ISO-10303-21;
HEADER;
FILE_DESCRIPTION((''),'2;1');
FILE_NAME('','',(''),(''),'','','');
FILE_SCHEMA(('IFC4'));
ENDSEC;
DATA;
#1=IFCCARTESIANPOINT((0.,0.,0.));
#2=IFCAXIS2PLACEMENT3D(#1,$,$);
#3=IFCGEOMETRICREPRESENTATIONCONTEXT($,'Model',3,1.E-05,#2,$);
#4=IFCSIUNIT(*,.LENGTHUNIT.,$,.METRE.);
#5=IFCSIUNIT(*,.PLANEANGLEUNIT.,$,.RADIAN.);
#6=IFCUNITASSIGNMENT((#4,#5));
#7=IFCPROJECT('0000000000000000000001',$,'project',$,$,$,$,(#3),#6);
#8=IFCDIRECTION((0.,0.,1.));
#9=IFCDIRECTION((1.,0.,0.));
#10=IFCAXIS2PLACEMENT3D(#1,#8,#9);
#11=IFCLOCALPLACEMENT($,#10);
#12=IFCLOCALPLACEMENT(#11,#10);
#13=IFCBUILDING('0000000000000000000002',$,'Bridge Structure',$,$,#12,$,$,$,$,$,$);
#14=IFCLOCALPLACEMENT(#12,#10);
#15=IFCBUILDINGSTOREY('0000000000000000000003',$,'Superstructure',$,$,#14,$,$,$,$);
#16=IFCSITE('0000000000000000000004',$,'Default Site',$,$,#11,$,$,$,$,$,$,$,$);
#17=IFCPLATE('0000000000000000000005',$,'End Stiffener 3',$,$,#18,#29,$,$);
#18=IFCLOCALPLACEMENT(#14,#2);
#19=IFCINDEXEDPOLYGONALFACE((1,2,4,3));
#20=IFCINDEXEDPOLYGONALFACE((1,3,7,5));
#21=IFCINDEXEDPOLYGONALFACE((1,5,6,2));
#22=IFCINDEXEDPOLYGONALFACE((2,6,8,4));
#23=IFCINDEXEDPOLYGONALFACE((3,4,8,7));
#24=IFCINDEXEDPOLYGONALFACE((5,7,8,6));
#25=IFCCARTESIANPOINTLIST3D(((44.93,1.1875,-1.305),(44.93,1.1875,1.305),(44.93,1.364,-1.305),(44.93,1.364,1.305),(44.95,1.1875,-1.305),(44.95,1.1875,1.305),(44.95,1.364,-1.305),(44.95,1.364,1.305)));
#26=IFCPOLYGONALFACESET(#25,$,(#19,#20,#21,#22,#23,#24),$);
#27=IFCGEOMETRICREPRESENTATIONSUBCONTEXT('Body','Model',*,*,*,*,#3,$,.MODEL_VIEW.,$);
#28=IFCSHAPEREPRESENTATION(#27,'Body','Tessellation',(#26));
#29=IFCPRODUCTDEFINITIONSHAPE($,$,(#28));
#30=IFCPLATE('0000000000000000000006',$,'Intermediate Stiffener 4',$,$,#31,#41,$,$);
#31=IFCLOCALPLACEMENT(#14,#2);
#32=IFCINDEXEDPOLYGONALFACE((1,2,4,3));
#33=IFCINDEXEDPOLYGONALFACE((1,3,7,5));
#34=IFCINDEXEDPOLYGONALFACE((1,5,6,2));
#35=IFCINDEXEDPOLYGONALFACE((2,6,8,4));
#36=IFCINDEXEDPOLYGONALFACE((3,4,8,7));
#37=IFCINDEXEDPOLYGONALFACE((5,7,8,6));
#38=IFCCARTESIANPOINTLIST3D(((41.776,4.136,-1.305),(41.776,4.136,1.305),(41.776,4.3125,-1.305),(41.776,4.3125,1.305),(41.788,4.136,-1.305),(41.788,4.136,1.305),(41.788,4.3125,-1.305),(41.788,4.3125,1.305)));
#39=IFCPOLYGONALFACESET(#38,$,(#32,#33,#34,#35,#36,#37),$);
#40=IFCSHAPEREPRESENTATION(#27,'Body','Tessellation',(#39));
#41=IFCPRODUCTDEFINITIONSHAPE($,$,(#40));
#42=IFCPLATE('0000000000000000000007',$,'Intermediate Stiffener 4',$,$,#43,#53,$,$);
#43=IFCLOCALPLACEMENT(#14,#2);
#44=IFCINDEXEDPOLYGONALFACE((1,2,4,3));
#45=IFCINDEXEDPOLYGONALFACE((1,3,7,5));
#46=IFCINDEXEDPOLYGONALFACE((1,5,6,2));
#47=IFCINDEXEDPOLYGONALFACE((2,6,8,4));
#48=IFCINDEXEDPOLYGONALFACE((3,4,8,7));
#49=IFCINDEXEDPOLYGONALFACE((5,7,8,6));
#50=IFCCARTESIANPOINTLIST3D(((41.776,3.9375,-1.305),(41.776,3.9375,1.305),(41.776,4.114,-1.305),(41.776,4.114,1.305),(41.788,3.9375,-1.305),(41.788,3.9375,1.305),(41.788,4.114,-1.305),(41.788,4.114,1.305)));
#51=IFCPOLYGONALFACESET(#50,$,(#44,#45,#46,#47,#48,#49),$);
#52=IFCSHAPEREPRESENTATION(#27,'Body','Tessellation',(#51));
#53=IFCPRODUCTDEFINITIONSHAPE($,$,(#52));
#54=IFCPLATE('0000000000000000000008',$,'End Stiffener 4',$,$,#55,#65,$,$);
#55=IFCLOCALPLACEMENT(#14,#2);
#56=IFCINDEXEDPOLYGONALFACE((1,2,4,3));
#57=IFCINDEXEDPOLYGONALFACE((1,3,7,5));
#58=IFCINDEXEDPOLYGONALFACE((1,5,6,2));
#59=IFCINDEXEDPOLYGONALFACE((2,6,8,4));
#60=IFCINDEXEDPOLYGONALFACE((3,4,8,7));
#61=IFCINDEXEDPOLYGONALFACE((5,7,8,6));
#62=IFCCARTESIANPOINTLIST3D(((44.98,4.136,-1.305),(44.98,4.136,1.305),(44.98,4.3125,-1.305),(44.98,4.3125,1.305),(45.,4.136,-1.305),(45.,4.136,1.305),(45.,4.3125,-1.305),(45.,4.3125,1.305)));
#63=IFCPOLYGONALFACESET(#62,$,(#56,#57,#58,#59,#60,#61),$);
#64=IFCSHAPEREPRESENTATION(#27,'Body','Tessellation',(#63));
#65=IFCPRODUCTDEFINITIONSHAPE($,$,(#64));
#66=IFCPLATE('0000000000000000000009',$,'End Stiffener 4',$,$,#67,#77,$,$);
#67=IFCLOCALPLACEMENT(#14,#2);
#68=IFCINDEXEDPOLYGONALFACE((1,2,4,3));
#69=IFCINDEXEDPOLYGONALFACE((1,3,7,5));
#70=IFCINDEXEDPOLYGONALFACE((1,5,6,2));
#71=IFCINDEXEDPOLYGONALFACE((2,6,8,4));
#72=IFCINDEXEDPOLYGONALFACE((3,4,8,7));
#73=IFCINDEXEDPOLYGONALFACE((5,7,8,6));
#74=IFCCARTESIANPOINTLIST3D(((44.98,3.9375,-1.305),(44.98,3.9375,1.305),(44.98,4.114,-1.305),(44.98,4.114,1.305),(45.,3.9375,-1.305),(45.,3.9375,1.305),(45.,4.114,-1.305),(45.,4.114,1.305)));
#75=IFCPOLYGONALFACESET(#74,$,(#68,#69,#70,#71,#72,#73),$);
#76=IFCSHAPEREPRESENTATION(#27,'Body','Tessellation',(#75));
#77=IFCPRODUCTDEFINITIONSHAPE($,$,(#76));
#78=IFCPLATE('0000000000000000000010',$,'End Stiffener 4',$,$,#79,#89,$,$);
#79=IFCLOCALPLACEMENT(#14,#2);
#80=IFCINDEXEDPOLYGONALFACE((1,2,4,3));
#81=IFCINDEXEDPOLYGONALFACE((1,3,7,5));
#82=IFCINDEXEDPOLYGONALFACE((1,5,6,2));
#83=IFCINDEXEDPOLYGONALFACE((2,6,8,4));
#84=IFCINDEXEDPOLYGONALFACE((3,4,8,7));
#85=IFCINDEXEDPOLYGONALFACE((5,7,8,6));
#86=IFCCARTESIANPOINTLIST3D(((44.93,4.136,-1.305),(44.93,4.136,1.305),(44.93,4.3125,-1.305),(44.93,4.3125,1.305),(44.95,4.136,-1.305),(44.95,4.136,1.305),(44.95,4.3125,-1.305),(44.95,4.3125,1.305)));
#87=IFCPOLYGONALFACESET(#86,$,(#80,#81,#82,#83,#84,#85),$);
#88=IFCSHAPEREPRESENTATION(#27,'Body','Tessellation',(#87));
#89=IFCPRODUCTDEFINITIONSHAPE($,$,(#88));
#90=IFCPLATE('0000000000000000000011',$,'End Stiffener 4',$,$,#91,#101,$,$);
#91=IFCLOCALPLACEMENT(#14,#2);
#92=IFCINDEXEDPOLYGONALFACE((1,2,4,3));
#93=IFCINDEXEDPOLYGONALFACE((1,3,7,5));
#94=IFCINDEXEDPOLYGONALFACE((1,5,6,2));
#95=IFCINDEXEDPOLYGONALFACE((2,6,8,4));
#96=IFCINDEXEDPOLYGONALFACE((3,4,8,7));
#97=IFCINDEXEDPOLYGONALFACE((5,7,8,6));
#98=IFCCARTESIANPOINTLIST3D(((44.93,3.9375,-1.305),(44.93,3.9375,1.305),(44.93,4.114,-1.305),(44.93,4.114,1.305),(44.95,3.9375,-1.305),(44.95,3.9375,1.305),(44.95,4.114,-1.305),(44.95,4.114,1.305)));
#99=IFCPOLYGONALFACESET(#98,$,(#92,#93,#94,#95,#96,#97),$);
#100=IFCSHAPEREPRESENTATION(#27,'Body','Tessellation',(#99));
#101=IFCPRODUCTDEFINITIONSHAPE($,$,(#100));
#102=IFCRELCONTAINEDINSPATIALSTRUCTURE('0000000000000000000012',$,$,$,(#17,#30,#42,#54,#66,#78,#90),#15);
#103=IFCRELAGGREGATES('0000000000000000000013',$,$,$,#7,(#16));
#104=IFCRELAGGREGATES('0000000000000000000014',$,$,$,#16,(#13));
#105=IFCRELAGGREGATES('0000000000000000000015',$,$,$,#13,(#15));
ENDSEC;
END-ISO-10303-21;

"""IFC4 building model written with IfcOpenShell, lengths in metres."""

from ifc_helpers import new_model, si_unit, frame, origin, origin_with_axes, origin_2d_with_axis, place, context, subcontext, project, spatial, rectangle, extrude, element, save


model = new_model("IFC4")

# Units and contexts
model_context = context("Model", 3, precision=1e-05, world=origin())
body_context = subcontext(model_context, "Body", "Model", "MODEL_VIEW")
ifc_project = project(units=[si_unit("LENGTHUNIT", "METRE"), si_unit("PLANEANGLEUNIT", "RADIAN")], contexts=[model_context])

# Site, building, storey
site_placement = place(None, origin_with_axes())
site = spatial("IfcSite", under=ifc_project, at=site_placement, Name="Default Site")
building_placement = place(site_placement, origin_with_axes())
building = spatial("IfcBuilding", under=site, at=building_placement, Name="Bridge Structure")
storey_placement = place(building_placement, origin_with_axes())
storey = spatial("IfcBuildingStorey", under=building, at=storey_placement, Name="Superstructure")

# Plates
for number, where, z_axis, x_axis, name in (
    (1, (44.94, 1.2757, -1.305), (0.0, 0.0, 1.0), (1.0, 0.0, 0.0), "End Stiffener 3"),
):
    element("IfcPlate", number, at=place(storey_placement, frame(where, z_axis=z_axis, x_axis=x_axis)), inside=storey, Name=name, context=body_context, shape_type="SweptSolid", body=[
        extrude(rectangle(XDim=0.02, YDim=0.1765, at=origin_2d_with_axis()), origin_with_axes(), (0.0, 0.0, 1.0), 2.61),
    ])
for number, where, z_axis, x_axis, name in (
    (2, (41.782, 4.2243, -1.305), (0.0, 0.0, 1.0), (1.0, 0.0, 0.0), "Intermediate Stiffener 4"),
    (3, (41.782, 4.0258, -1.305), (0.0, 0.0, 1.0), (1.0, 0.0, 0.0), "Intermediate Stiffener 4"),
):
    element("IfcPlate", number, at=place(storey_placement, frame(where, z_axis=z_axis, x_axis=x_axis)), inside=storey, Name=name, context=body_context, shape_type="SweptSolid", body=[
        extrude(rectangle(XDim=0.012, YDim=0.1765, at=origin_2d_with_axis()), origin_with_axes(), (0.0, 0.0, 1.0), 2.61),
    ])
for number, where, z_axis, x_axis, name in (
    (4, (44.99, 4.2243, -1.305), (0.0, 0.0, 1.0), (1.0, 0.0, 0.0), "End Stiffener 4"),
    (5, (44.99, 4.0258, -1.305), (0.0, 0.0, 1.0), (1.0, 0.0, 0.0), "End Stiffener 4"),
    (6, (44.94, 4.2243, -1.305), (0.0, 0.0, 1.0), (1.0, 0.0, 0.0), "End Stiffener 4"),
    (7, (44.94, 4.0258, -1.305), (0.0, 0.0, 1.0), (1.0, 0.0, 0.0), "End Stiffener 4"),
):
    element("IfcPlate", number, at=place(storey_placement, frame(where, z_axis=z_axis, x_axis=x_axis)), inside=storey, Name=name, context=body_context, shape_type="SweptSolid", body=[
        extrude(rectangle(XDim=0.02, YDim=0.1765, at=origin_2d_with_axis()), origin_with_axes(), (0.0, 0.0, 1.0), 2.61),
    ])

save(model, "model.ifc")
